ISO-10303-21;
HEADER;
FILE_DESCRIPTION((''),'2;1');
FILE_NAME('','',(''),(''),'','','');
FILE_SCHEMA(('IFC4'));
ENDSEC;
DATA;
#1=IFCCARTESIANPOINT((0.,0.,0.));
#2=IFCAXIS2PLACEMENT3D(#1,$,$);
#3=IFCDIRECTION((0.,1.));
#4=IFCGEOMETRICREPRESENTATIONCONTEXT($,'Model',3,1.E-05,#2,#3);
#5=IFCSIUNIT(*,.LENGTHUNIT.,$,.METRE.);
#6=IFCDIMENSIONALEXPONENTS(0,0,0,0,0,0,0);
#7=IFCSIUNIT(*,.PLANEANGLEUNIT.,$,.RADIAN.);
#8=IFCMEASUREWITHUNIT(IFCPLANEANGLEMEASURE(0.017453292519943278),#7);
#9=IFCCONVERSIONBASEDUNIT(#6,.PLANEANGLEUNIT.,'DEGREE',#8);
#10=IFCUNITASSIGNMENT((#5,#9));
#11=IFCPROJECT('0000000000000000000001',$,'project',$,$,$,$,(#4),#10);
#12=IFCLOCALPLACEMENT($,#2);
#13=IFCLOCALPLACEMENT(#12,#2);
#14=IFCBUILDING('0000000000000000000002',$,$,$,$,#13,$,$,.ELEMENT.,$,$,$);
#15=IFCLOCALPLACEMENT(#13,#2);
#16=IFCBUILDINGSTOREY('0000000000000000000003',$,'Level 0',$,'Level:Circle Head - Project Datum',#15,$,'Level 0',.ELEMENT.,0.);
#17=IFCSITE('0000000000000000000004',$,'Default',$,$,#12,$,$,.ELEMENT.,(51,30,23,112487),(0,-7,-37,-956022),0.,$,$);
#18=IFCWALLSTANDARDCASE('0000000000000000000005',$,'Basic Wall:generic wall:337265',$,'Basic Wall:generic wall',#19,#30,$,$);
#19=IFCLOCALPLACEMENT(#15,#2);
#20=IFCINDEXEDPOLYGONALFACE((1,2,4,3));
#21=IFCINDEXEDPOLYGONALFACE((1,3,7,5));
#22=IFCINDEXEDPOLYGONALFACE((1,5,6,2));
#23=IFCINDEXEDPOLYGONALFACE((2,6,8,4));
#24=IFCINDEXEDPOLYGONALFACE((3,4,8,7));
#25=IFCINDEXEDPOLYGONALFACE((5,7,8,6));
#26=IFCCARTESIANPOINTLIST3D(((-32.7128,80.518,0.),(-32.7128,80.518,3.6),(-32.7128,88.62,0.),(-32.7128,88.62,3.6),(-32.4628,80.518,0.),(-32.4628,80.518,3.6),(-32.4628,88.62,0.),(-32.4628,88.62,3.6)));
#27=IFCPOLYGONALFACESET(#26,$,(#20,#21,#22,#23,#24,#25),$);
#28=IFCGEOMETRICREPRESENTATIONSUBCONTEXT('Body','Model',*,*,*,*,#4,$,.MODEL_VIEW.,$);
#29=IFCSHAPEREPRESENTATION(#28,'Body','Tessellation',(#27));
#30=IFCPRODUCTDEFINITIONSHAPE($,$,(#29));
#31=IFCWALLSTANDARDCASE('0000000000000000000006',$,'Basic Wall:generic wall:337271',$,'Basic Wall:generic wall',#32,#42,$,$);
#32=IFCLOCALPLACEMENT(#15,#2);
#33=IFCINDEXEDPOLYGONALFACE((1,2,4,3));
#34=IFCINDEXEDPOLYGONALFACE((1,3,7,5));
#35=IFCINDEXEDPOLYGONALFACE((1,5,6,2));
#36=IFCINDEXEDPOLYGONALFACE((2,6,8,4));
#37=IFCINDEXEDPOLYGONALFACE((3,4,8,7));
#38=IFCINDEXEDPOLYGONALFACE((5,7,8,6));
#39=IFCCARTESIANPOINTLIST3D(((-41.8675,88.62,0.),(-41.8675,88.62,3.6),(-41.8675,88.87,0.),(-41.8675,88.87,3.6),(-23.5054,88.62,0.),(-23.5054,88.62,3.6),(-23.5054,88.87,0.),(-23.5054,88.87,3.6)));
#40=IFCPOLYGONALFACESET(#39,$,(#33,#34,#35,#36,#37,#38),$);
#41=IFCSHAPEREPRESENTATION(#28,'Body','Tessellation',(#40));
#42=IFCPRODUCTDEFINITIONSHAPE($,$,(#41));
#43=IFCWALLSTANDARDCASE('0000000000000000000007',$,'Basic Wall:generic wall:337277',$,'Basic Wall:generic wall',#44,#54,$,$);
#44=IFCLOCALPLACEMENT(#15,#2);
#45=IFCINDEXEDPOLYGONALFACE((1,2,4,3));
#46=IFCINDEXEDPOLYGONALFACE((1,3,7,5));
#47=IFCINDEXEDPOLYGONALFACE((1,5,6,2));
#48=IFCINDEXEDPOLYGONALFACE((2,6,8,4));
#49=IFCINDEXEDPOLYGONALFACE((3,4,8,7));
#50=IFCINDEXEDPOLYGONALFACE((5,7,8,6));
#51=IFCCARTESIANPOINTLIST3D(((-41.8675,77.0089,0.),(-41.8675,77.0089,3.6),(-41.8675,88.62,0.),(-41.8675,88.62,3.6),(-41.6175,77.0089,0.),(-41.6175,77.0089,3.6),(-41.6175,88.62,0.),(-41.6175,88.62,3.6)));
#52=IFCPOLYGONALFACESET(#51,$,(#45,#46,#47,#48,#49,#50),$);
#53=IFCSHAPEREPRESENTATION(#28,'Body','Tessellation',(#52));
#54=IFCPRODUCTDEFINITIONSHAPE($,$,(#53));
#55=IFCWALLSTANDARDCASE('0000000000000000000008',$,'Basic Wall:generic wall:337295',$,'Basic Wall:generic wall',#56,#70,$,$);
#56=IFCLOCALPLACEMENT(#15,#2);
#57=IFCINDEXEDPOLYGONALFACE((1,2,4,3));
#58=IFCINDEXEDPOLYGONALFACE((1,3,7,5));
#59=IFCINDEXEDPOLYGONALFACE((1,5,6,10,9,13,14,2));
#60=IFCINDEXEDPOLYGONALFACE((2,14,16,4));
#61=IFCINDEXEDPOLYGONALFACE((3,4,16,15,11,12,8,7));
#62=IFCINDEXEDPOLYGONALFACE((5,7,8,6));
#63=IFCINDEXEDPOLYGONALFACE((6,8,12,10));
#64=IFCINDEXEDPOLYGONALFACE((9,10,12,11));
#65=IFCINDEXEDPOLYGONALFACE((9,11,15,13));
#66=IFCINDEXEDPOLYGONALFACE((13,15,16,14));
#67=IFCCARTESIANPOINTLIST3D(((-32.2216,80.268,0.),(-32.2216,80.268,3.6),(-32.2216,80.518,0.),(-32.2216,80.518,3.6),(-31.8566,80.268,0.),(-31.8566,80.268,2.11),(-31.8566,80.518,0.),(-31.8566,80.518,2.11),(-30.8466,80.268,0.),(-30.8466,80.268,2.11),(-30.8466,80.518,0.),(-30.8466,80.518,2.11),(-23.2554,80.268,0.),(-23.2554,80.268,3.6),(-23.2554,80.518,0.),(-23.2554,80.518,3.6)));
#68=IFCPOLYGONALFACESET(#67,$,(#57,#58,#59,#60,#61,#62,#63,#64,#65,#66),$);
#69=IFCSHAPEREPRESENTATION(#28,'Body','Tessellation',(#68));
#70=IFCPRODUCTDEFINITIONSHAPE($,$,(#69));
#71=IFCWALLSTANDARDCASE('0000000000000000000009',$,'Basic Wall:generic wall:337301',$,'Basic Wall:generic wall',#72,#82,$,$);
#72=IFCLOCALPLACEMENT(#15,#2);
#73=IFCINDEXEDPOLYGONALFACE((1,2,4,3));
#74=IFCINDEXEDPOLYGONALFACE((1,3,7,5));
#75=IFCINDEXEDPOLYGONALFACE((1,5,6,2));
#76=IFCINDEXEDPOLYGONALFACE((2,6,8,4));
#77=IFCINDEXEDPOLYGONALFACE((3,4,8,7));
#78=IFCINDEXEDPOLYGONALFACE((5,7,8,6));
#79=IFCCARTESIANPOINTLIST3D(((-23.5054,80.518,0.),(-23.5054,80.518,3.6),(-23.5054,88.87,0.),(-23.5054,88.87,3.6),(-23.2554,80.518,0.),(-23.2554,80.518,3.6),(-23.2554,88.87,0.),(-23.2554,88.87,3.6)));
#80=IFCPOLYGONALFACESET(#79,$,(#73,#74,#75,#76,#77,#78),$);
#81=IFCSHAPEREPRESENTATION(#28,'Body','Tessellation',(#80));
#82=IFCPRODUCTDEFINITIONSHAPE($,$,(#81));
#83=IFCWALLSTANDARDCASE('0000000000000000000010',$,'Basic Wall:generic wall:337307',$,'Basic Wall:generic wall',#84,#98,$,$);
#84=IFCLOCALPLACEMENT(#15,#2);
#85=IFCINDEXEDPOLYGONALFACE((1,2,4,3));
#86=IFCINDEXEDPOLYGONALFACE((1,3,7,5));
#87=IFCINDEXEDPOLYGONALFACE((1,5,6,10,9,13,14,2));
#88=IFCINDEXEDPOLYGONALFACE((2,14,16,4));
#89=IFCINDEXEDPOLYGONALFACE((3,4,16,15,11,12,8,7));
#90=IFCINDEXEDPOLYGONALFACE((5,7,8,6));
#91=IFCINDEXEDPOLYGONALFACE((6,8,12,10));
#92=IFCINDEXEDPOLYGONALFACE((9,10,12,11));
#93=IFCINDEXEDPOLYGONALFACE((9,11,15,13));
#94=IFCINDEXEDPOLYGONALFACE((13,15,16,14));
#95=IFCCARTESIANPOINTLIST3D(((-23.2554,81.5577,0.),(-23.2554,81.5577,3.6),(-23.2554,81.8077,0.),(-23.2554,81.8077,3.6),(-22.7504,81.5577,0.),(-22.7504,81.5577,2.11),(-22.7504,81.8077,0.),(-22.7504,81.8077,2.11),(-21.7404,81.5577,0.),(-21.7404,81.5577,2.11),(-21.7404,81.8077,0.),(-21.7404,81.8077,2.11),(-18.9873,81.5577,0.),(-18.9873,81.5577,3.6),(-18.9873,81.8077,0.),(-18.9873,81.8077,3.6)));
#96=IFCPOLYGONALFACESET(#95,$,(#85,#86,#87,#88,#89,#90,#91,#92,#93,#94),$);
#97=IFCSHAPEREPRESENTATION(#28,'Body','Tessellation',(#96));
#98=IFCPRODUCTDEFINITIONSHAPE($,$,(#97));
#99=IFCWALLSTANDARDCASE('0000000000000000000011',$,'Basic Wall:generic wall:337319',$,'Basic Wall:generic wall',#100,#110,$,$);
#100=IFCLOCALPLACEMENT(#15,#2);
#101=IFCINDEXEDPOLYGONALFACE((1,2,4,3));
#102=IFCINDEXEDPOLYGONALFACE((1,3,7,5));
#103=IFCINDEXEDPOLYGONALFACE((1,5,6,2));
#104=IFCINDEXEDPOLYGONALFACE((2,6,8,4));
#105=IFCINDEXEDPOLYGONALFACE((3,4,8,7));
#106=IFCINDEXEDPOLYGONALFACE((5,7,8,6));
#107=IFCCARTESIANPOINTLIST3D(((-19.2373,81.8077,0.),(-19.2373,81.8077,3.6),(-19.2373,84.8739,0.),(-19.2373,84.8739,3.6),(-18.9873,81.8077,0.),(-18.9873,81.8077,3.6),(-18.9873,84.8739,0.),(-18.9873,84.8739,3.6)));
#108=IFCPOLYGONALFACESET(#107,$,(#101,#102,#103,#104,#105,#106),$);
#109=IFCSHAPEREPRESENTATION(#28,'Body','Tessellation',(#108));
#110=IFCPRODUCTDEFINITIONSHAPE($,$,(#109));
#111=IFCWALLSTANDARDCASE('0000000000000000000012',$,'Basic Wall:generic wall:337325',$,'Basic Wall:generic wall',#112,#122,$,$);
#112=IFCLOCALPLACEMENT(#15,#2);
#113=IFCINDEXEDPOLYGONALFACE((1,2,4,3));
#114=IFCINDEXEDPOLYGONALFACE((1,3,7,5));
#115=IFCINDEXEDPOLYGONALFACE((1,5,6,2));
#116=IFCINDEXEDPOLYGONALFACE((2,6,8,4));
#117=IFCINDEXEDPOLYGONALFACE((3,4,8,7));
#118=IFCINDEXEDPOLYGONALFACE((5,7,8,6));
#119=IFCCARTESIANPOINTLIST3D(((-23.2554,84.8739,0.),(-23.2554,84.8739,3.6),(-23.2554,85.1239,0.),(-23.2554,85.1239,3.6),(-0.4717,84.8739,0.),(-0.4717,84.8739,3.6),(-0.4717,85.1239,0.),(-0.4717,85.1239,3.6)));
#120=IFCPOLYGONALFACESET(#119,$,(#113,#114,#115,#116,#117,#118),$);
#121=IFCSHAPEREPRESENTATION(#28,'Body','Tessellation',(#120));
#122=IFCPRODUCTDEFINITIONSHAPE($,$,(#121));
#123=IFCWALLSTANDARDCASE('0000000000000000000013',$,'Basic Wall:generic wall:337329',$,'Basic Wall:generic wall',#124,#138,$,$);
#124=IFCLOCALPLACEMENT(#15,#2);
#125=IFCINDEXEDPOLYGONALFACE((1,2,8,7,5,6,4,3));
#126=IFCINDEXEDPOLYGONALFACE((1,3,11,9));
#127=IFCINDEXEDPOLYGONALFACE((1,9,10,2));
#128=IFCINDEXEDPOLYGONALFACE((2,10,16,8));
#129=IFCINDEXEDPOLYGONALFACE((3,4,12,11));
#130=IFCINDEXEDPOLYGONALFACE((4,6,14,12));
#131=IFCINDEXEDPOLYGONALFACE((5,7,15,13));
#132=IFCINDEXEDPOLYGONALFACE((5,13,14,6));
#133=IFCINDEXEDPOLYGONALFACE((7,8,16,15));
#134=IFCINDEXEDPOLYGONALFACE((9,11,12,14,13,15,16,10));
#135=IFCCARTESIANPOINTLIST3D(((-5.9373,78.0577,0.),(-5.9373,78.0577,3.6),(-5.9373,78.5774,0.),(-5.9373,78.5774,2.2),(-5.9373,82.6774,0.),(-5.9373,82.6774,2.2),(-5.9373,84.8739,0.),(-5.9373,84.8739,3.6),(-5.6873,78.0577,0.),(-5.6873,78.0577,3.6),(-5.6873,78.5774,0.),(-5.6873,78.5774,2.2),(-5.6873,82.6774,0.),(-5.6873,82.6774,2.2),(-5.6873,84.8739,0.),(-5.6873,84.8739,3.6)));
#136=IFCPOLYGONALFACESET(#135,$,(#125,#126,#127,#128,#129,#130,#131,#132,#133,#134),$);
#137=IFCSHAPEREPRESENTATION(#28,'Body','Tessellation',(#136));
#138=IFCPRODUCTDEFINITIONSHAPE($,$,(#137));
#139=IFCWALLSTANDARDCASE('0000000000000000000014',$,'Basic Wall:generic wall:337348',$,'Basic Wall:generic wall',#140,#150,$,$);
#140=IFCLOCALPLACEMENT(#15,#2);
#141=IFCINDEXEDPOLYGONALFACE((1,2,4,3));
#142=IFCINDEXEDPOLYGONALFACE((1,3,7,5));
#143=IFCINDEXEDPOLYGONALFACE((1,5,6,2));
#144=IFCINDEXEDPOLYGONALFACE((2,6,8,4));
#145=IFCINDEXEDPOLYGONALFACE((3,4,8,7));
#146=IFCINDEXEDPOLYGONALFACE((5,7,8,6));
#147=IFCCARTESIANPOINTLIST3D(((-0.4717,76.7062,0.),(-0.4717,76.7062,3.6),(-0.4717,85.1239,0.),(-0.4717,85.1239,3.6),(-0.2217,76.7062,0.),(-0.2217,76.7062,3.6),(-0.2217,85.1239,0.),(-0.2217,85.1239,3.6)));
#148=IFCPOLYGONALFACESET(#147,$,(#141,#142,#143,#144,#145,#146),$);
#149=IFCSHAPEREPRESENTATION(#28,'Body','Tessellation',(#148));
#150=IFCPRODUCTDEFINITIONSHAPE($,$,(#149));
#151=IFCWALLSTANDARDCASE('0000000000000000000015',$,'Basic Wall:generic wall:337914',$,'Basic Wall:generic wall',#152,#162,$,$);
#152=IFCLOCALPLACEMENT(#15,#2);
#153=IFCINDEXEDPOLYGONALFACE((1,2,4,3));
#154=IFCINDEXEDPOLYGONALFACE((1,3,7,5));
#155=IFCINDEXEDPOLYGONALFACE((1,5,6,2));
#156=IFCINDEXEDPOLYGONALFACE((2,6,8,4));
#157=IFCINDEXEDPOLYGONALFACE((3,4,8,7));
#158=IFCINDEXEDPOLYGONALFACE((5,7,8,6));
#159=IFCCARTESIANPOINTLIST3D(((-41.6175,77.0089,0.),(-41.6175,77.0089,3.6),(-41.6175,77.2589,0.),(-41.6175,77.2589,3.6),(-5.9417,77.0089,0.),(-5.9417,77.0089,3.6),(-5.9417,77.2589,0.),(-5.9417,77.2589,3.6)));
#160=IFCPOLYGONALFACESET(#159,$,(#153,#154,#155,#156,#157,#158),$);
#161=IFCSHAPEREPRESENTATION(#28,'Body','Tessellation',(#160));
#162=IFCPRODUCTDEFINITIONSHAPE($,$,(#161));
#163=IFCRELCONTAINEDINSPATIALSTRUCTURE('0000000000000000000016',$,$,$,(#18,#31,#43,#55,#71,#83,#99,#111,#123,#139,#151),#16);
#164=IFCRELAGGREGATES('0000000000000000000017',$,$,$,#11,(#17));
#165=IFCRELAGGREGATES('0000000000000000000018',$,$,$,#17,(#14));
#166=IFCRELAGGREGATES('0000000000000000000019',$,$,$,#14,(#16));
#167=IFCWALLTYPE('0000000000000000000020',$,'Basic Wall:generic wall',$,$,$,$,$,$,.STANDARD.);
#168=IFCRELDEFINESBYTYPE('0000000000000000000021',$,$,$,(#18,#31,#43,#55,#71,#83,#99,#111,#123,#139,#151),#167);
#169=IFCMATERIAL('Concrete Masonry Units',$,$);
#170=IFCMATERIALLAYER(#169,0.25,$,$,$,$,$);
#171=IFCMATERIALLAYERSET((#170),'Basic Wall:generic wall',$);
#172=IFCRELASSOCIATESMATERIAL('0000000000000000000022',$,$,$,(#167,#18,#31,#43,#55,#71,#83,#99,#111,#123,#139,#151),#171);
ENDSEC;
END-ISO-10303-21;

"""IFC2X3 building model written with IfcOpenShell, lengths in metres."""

from ifc_helpers import new_model, entity, si_unit, converted_unit, direction, frame, frame_2d, origin, place, context, subcontext, project, spatial, rectangle, extrude, material, layer, layer_set, layer_usage, type_object, element, save


model = new_model("IFC2X3")

# Units and contexts
model_context = context("Model", 3, precision=1e-05, world=origin(), true_north=direction((0.0, 1.0)))
body_context = subcontext(model_context, "Body", "Model", "MODEL_VIEW")
ifc_project = project(units=[si_unit("LENGTHUNIT", "METRE"), converted_unit("PLANEANGLEUNIT", "DEGREE", entity("IfcPlaneAngleMeasure", 0.017453292519943278), si_unit("PLANEANGLEUNIT", "RADIAN"), dimensions=[0, 0, 0, 0, 0, 0, 0])], contexts=[model_context])

# Site, building, storey
site_placement = place(None, origin())
site = spatial("IfcSite", under=ifc_project, at=site_placement, Name="Default", CompositionType="ELEMENT", RefLatitude=(51, 30, 23, 112487), RefLongitude=(0, -7, -37, -956022), RefElevation=0.0)
building_placement = place(site_placement, origin())
building = spatial("IfcBuilding", under=site, at=building_placement, CompositionType="ELEMENT")
storey_placement = place(building_placement, origin())
storey = spatial("IfcBuildingStorey", under=building, at=storey_placement, Name="Level 0", ObjectType="Level:Circle Head - Project Datum", LongName="Level 0", CompositionType="ELEMENT", Elevation=0.0)

# Walls
ifc_material = material(Name="Concrete Masonry Units")
ifc_layer = layer(ifc_material, 0.25)
ifc_layer_set = layer_set([ifc_layer], Name="Basic Wall:generic wall")
ifc_layer_usage_1 = layer_usage(ifc_layer_set, "AXIS2", "NEGATIVE", 0.125)
wall_type = type_object("IfcWallType", Name="Basic Wall:generic wall", PredefinedType="STANDARD", material=ifc_layer_set)
wall_1_placement = place(storey_placement, frame((-32.5878, 80.518, 0.0), z_axis=(0.0, 0.0, 1.0), x_axis=(0.0, 1.0, 0.0)))
element("IfcWallStandardCase", 1, at=wall_1_placement, inside=storey, type_object=wall_type, material=ifc_layer_usage_1, Name="Basic Wall:generic wall:337265", ObjectType="Basic Wall:generic wall", context=body_context, shape_type="SweptSolid", body=[
    extrude(rectangle(XDim=8.102, YDim=0.25, at=frame_2d((4.051, 0.0), x_axis=(-1.0, 0.0))), origin(), (0.0, 0.0, 1.0), 3.6),
])
ifc_layer_usage_2 = layer_usage(ifc_layer_set, "AXIS2", "NEGATIVE", 0.125)
wall_2_placement = place(storey_placement, frame((-23.5054, 88.745, 0.0), z_axis=(0.0, 0.0, 1.0), x_axis=(-1.0, 0.0, 0.0)))
element("IfcWallStandardCase", 2, at=wall_2_placement, inside=storey, type_object=wall_type, material=ifc_layer_usage_2, Name="Basic Wall:generic wall:337271", ObjectType="Basic Wall:generic wall", context=body_context, shape_type="SweptSolid", body=[
    extrude(rectangle(XDim=18.3621, YDim=0.25, at=frame_2d((9.1811, 0.0), x_axis=(-1.0, 0.0))), origin(), (0.0, 0.0, 1.0), 3.6),
])
ifc_layer_usage_3 = layer_usage(ifc_layer_set, "AXIS2", "NEGATIVE", 0.125)
wall_3_placement = place(storey_placement, frame((-41.7425, 88.62, 0.0), z_axis=(0.0, 0.0, 1.0), x_axis=(0.0, -1.0, 0.0)))
element("IfcWallStandardCase", 3, at=wall_3_placement, inside=storey, type_object=wall_type, material=ifc_layer_usage_3, Name="Basic Wall:generic wall:337277", ObjectType="Basic Wall:generic wall", context=body_context, shape_type="SweptSolid", body=[
    extrude(rectangle(XDim=11.6112, YDim=0.25, at=frame_2d((5.8056, 0.0), x_axis=(-1.0, 0.0))), origin(), (0.0, 0.0, 1.0), 3.6),
])

# Wall, opening
ifc_layer_usage_4 = layer_usage(ifc_layer_set, "AXIS2", "NEGATIVE", 0.125)
wall_4_placement = place(storey_placement, frame((-23.2554, 80.393, 0.0), z_axis=(0.0, 0.0, 1.0), x_axis=(-1.0, 0.0, 0.0)))
wall_4 = element("IfcWallStandardCase", 4, at=wall_4_placement, inside=storey, type_object=wall_type, material=ifc_layer_usage_4, Name="Basic Wall:generic wall:337295", ObjectType="Basic Wall:generic wall", context=body_context, shape_type="SweptSolid", body=[
    extrude(rectangle(XDim=8.9661, YDim=0.25, at=frame_2d((4.4831, 0.0), x_axis=(-1.0, 0.0))), origin(), (0.0, 0.0, 1.0), 3.6),
])
opening_1_placement = place(wall_4_placement, frame((8.6011, 0.125, 0.0)))
element("IfcOpeningElement", 5, at=opening_1_placement, cuts=wall_4, ObjectType="Opening", context=body_context, shape_type="SweptSolid", body=[
    extrude(rectangle(XDim=2.11, YDim=1.01, at=frame_2d((1.055, 0.505), x_axis=(1.0, 0.0))), frame((0.0, 0.0, 0.0), z_axis=(0.0, -1.0, 0.0), x_axis=(0.0, 0.0, 1.0)), (0.0, 0.0, 1.0), 0.25),
])

# Wall
ifc_layer_usage_5 = layer_usage(ifc_layer_set, "AXIS2", "NEGATIVE", 0.125)
wall_5_placement = place(storey_placement, frame((-23.3804, 88.87, 0.0), z_axis=(0.0, 0.0, 1.0), x_axis=(0.0, -1.0, 0.0)))
element("IfcWallStandardCase", 6, at=wall_5_placement, inside=storey, type_object=wall_type, material=ifc_layer_usage_5, Name="Basic Wall:generic wall:337301", ObjectType="Basic Wall:generic wall", context=body_context, shape_type="SweptSolid", body=[
    extrude(rectangle(XDim=8.352, YDim=0.25, at=frame_2d((4.176, 0.0), x_axis=(-1.0, 0.0))), origin(), (0.0, 0.0, 1.0), 3.6),
])

# Wall, opening
ifc_layer_usage_6 = layer_usage(ifc_layer_set, "AXIS2", "NEGATIVE", 0.125)
wall_6_placement = place(storey_placement, frame((-18.9873, 81.6827, 0.0), z_axis=(0.0, 0.0, 1.0), x_axis=(-1.0, 0.0, 0.0)))
wall_6 = element("IfcWallStandardCase", 7, at=wall_6_placement, inside=storey, type_object=wall_type, material=ifc_layer_usage_6, Name="Basic Wall:generic wall:337307", ObjectType="Basic Wall:generic wall", context=body_context, shape_type="SweptSolid", body=[
    extrude(rectangle(XDim=4.2681, YDim=0.25, at=frame_2d((2.1341, 0.0), x_axis=(-1.0, 0.0))), origin(), (0.0, 0.0, 1.0), 3.6),
])
opening_2_placement = place(wall_6_placement, frame((3.7631, 0.125, 0.0)))
element("IfcOpeningElement", 8, at=opening_2_placement, cuts=wall_6, ObjectType="Opening", context=body_context, shape_type="SweptSolid", body=[
    extrude(rectangle(XDim=2.11, YDim=1.01, at=frame_2d((1.055, 0.505), x_axis=(1.0, 0.0))), frame((0.0, 0.0, 0.0), z_axis=(0.0, -1.0, 0.0), x_axis=(0.0, 0.0, 1.0)), (0.0, 0.0, 1.0), 0.25),
])

# Walls
ifc_layer_usage_7 = layer_usage(ifc_layer_set, "AXIS2", "NEGATIVE", 0.125)
wall_7_placement = place(storey_placement, frame((-19.1123, 84.8739, 0.0), z_axis=(0.0, 0.0, 1.0), x_axis=(0.0, -1.0, 0.0)))
element("IfcWallStandardCase", 9, at=wall_7_placement, inside=storey, type_object=wall_type, material=ifc_layer_usage_7, Name="Basic Wall:generic wall:337319", ObjectType="Basic Wall:generic wall", context=body_context, shape_type="SweptSolid", body=[
    extrude(rectangle(XDim=3.0662, YDim=0.25, at=frame_2d((1.5331, 0.0), x_axis=(-1.0, 0.0))), origin(), (0.0, 0.0, 1.0), 3.6),
])
ifc_layer_usage_8 = layer_usage(ifc_layer_set, "AXIS2", "NEGATIVE", 0.125)
wall_8_placement = place(storey_placement, frame((-0.4717, 84.9989, 0.0), z_axis=(0.0, 0.0, 1.0), x_axis=(-1.0, 0.0, 0.0)))
element("IfcWallStandardCase", 10, at=wall_8_placement, inside=storey, type_object=wall_type, material=ifc_layer_usage_8, Name="Basic Wall:generic wall:337325", ObjectType="Basic Wall:generic wall", context=body_context, shape_type="SweptSolid", body=[
    extrude(rectangle(XDim=22.7838, YDim=0.25, at=frame_2d((11.3919, 0.0), x_axis=(-1.0, 0.0))), origin(), (0.0, 0.0, 1.0), 3.6),
])

# Wall, opening
ifc_layer_usage_9 = layer_usage(ifc_layer_set, "AXIS2", "NEGATIVE", 0.125)
wall_9_placement = place(storey_placement, frame((-5.8123, 78.0577, 0.0), z_axis=(0.0, 0.0, 1.0), x_axis=(0.0, 1.0, 0.0)))
wall_9 = element("IfcWallStandardCase", 11, at=wall_9_placement, inside=storey, type_object=wall_type, material=ifc_layer_usage_9, Name="Basic Wall:generic wall:337329", ObjectType="Basic Wall:generic wall", context=body_context, shape_type="SweptSolid", body=[
    extrude(rectangle(XDim=6.8162, YDim=0.25, at=frame_2d((3.4081, 0.0), x_axis=(1.0, 0.0))), origin(), (0.0, 0.0, 1.0), 3.6),
])
opening_3_placement = place(wall_9_placement, frame((4.6198, 0.125, 0.0)))
element("IfcOpeningElement", 12, at=opening_3_placement, cuts=wall_9, ObjectType="Opening", context=body_context, shape_type="SweptSolid", body=[
    extrude(rectangle(XDim=2.2, YDim=4.1, at=frame_2d((1.1, 2.05), x_axis=(1.0, 0.0))), frame((0.0, 0.0, 0.0), z_axis=(0.0, -1.0, 0.0), x_axis=(0.0, 0.0, 1.0)), (0.0, 0.0, 1.0), 0.25),
])

# Walls
ifc_layer_usage_10 = layer_usage(ifc_layer_set, "AXIS2", "POSITIVE", -0.125)
wall_10_placement = place(storey_placement, frame((-0.3467, 85.1239, 0.0), z_axis=(0.0, 0.0, 1.0), x_axis=(0.0, -1.0, 0.0)))
element("IfcWallStandardCase", 13, at=wall_10_placement, inside=storey, type_object=wall_type, material=ifc_layer_usage_10, Name="Basic Wall:generic wall:337348", ObjectType="Basic Wall:generic wall", context=body_context, shape_type="SweptSolid", body=[
    extrude(rectangle(XDim=8.4178, YDim=0.25, at=frame_2d((4.2089, 0.0), x_axis=(-1.0, 0.0))), origin(), (0.0, 0.0, 1.0), 3.6),
])
ifc_layer_usage_11 = layer_usage(ifc_layer_set, "AXIS2", "NEGATIVE", 0.125)
wall_11_placement = place(storey_placement, frame((-41.6175, 77.1339, 0.0)))
element("IfcWallStandardCase", 14, at=wall_11_placement, inside=storey, type_object=wall_type, material=ifc_layer_usage_11, Name="Basic Wall:generic wall:337914", ObjectType="Basic Wall:generic wall", context=body_context, shape_type="SweptSolid", body=[
    extrude(rectangle(XDim=35.6759, YDim=0.25, at=frame_2d((17.8379, 0.0), x_axis=(-1.0, 0.0))), origin(), (0.0, 0.0, 1.0), 3.6),
])

save(model, "model.ifc")
